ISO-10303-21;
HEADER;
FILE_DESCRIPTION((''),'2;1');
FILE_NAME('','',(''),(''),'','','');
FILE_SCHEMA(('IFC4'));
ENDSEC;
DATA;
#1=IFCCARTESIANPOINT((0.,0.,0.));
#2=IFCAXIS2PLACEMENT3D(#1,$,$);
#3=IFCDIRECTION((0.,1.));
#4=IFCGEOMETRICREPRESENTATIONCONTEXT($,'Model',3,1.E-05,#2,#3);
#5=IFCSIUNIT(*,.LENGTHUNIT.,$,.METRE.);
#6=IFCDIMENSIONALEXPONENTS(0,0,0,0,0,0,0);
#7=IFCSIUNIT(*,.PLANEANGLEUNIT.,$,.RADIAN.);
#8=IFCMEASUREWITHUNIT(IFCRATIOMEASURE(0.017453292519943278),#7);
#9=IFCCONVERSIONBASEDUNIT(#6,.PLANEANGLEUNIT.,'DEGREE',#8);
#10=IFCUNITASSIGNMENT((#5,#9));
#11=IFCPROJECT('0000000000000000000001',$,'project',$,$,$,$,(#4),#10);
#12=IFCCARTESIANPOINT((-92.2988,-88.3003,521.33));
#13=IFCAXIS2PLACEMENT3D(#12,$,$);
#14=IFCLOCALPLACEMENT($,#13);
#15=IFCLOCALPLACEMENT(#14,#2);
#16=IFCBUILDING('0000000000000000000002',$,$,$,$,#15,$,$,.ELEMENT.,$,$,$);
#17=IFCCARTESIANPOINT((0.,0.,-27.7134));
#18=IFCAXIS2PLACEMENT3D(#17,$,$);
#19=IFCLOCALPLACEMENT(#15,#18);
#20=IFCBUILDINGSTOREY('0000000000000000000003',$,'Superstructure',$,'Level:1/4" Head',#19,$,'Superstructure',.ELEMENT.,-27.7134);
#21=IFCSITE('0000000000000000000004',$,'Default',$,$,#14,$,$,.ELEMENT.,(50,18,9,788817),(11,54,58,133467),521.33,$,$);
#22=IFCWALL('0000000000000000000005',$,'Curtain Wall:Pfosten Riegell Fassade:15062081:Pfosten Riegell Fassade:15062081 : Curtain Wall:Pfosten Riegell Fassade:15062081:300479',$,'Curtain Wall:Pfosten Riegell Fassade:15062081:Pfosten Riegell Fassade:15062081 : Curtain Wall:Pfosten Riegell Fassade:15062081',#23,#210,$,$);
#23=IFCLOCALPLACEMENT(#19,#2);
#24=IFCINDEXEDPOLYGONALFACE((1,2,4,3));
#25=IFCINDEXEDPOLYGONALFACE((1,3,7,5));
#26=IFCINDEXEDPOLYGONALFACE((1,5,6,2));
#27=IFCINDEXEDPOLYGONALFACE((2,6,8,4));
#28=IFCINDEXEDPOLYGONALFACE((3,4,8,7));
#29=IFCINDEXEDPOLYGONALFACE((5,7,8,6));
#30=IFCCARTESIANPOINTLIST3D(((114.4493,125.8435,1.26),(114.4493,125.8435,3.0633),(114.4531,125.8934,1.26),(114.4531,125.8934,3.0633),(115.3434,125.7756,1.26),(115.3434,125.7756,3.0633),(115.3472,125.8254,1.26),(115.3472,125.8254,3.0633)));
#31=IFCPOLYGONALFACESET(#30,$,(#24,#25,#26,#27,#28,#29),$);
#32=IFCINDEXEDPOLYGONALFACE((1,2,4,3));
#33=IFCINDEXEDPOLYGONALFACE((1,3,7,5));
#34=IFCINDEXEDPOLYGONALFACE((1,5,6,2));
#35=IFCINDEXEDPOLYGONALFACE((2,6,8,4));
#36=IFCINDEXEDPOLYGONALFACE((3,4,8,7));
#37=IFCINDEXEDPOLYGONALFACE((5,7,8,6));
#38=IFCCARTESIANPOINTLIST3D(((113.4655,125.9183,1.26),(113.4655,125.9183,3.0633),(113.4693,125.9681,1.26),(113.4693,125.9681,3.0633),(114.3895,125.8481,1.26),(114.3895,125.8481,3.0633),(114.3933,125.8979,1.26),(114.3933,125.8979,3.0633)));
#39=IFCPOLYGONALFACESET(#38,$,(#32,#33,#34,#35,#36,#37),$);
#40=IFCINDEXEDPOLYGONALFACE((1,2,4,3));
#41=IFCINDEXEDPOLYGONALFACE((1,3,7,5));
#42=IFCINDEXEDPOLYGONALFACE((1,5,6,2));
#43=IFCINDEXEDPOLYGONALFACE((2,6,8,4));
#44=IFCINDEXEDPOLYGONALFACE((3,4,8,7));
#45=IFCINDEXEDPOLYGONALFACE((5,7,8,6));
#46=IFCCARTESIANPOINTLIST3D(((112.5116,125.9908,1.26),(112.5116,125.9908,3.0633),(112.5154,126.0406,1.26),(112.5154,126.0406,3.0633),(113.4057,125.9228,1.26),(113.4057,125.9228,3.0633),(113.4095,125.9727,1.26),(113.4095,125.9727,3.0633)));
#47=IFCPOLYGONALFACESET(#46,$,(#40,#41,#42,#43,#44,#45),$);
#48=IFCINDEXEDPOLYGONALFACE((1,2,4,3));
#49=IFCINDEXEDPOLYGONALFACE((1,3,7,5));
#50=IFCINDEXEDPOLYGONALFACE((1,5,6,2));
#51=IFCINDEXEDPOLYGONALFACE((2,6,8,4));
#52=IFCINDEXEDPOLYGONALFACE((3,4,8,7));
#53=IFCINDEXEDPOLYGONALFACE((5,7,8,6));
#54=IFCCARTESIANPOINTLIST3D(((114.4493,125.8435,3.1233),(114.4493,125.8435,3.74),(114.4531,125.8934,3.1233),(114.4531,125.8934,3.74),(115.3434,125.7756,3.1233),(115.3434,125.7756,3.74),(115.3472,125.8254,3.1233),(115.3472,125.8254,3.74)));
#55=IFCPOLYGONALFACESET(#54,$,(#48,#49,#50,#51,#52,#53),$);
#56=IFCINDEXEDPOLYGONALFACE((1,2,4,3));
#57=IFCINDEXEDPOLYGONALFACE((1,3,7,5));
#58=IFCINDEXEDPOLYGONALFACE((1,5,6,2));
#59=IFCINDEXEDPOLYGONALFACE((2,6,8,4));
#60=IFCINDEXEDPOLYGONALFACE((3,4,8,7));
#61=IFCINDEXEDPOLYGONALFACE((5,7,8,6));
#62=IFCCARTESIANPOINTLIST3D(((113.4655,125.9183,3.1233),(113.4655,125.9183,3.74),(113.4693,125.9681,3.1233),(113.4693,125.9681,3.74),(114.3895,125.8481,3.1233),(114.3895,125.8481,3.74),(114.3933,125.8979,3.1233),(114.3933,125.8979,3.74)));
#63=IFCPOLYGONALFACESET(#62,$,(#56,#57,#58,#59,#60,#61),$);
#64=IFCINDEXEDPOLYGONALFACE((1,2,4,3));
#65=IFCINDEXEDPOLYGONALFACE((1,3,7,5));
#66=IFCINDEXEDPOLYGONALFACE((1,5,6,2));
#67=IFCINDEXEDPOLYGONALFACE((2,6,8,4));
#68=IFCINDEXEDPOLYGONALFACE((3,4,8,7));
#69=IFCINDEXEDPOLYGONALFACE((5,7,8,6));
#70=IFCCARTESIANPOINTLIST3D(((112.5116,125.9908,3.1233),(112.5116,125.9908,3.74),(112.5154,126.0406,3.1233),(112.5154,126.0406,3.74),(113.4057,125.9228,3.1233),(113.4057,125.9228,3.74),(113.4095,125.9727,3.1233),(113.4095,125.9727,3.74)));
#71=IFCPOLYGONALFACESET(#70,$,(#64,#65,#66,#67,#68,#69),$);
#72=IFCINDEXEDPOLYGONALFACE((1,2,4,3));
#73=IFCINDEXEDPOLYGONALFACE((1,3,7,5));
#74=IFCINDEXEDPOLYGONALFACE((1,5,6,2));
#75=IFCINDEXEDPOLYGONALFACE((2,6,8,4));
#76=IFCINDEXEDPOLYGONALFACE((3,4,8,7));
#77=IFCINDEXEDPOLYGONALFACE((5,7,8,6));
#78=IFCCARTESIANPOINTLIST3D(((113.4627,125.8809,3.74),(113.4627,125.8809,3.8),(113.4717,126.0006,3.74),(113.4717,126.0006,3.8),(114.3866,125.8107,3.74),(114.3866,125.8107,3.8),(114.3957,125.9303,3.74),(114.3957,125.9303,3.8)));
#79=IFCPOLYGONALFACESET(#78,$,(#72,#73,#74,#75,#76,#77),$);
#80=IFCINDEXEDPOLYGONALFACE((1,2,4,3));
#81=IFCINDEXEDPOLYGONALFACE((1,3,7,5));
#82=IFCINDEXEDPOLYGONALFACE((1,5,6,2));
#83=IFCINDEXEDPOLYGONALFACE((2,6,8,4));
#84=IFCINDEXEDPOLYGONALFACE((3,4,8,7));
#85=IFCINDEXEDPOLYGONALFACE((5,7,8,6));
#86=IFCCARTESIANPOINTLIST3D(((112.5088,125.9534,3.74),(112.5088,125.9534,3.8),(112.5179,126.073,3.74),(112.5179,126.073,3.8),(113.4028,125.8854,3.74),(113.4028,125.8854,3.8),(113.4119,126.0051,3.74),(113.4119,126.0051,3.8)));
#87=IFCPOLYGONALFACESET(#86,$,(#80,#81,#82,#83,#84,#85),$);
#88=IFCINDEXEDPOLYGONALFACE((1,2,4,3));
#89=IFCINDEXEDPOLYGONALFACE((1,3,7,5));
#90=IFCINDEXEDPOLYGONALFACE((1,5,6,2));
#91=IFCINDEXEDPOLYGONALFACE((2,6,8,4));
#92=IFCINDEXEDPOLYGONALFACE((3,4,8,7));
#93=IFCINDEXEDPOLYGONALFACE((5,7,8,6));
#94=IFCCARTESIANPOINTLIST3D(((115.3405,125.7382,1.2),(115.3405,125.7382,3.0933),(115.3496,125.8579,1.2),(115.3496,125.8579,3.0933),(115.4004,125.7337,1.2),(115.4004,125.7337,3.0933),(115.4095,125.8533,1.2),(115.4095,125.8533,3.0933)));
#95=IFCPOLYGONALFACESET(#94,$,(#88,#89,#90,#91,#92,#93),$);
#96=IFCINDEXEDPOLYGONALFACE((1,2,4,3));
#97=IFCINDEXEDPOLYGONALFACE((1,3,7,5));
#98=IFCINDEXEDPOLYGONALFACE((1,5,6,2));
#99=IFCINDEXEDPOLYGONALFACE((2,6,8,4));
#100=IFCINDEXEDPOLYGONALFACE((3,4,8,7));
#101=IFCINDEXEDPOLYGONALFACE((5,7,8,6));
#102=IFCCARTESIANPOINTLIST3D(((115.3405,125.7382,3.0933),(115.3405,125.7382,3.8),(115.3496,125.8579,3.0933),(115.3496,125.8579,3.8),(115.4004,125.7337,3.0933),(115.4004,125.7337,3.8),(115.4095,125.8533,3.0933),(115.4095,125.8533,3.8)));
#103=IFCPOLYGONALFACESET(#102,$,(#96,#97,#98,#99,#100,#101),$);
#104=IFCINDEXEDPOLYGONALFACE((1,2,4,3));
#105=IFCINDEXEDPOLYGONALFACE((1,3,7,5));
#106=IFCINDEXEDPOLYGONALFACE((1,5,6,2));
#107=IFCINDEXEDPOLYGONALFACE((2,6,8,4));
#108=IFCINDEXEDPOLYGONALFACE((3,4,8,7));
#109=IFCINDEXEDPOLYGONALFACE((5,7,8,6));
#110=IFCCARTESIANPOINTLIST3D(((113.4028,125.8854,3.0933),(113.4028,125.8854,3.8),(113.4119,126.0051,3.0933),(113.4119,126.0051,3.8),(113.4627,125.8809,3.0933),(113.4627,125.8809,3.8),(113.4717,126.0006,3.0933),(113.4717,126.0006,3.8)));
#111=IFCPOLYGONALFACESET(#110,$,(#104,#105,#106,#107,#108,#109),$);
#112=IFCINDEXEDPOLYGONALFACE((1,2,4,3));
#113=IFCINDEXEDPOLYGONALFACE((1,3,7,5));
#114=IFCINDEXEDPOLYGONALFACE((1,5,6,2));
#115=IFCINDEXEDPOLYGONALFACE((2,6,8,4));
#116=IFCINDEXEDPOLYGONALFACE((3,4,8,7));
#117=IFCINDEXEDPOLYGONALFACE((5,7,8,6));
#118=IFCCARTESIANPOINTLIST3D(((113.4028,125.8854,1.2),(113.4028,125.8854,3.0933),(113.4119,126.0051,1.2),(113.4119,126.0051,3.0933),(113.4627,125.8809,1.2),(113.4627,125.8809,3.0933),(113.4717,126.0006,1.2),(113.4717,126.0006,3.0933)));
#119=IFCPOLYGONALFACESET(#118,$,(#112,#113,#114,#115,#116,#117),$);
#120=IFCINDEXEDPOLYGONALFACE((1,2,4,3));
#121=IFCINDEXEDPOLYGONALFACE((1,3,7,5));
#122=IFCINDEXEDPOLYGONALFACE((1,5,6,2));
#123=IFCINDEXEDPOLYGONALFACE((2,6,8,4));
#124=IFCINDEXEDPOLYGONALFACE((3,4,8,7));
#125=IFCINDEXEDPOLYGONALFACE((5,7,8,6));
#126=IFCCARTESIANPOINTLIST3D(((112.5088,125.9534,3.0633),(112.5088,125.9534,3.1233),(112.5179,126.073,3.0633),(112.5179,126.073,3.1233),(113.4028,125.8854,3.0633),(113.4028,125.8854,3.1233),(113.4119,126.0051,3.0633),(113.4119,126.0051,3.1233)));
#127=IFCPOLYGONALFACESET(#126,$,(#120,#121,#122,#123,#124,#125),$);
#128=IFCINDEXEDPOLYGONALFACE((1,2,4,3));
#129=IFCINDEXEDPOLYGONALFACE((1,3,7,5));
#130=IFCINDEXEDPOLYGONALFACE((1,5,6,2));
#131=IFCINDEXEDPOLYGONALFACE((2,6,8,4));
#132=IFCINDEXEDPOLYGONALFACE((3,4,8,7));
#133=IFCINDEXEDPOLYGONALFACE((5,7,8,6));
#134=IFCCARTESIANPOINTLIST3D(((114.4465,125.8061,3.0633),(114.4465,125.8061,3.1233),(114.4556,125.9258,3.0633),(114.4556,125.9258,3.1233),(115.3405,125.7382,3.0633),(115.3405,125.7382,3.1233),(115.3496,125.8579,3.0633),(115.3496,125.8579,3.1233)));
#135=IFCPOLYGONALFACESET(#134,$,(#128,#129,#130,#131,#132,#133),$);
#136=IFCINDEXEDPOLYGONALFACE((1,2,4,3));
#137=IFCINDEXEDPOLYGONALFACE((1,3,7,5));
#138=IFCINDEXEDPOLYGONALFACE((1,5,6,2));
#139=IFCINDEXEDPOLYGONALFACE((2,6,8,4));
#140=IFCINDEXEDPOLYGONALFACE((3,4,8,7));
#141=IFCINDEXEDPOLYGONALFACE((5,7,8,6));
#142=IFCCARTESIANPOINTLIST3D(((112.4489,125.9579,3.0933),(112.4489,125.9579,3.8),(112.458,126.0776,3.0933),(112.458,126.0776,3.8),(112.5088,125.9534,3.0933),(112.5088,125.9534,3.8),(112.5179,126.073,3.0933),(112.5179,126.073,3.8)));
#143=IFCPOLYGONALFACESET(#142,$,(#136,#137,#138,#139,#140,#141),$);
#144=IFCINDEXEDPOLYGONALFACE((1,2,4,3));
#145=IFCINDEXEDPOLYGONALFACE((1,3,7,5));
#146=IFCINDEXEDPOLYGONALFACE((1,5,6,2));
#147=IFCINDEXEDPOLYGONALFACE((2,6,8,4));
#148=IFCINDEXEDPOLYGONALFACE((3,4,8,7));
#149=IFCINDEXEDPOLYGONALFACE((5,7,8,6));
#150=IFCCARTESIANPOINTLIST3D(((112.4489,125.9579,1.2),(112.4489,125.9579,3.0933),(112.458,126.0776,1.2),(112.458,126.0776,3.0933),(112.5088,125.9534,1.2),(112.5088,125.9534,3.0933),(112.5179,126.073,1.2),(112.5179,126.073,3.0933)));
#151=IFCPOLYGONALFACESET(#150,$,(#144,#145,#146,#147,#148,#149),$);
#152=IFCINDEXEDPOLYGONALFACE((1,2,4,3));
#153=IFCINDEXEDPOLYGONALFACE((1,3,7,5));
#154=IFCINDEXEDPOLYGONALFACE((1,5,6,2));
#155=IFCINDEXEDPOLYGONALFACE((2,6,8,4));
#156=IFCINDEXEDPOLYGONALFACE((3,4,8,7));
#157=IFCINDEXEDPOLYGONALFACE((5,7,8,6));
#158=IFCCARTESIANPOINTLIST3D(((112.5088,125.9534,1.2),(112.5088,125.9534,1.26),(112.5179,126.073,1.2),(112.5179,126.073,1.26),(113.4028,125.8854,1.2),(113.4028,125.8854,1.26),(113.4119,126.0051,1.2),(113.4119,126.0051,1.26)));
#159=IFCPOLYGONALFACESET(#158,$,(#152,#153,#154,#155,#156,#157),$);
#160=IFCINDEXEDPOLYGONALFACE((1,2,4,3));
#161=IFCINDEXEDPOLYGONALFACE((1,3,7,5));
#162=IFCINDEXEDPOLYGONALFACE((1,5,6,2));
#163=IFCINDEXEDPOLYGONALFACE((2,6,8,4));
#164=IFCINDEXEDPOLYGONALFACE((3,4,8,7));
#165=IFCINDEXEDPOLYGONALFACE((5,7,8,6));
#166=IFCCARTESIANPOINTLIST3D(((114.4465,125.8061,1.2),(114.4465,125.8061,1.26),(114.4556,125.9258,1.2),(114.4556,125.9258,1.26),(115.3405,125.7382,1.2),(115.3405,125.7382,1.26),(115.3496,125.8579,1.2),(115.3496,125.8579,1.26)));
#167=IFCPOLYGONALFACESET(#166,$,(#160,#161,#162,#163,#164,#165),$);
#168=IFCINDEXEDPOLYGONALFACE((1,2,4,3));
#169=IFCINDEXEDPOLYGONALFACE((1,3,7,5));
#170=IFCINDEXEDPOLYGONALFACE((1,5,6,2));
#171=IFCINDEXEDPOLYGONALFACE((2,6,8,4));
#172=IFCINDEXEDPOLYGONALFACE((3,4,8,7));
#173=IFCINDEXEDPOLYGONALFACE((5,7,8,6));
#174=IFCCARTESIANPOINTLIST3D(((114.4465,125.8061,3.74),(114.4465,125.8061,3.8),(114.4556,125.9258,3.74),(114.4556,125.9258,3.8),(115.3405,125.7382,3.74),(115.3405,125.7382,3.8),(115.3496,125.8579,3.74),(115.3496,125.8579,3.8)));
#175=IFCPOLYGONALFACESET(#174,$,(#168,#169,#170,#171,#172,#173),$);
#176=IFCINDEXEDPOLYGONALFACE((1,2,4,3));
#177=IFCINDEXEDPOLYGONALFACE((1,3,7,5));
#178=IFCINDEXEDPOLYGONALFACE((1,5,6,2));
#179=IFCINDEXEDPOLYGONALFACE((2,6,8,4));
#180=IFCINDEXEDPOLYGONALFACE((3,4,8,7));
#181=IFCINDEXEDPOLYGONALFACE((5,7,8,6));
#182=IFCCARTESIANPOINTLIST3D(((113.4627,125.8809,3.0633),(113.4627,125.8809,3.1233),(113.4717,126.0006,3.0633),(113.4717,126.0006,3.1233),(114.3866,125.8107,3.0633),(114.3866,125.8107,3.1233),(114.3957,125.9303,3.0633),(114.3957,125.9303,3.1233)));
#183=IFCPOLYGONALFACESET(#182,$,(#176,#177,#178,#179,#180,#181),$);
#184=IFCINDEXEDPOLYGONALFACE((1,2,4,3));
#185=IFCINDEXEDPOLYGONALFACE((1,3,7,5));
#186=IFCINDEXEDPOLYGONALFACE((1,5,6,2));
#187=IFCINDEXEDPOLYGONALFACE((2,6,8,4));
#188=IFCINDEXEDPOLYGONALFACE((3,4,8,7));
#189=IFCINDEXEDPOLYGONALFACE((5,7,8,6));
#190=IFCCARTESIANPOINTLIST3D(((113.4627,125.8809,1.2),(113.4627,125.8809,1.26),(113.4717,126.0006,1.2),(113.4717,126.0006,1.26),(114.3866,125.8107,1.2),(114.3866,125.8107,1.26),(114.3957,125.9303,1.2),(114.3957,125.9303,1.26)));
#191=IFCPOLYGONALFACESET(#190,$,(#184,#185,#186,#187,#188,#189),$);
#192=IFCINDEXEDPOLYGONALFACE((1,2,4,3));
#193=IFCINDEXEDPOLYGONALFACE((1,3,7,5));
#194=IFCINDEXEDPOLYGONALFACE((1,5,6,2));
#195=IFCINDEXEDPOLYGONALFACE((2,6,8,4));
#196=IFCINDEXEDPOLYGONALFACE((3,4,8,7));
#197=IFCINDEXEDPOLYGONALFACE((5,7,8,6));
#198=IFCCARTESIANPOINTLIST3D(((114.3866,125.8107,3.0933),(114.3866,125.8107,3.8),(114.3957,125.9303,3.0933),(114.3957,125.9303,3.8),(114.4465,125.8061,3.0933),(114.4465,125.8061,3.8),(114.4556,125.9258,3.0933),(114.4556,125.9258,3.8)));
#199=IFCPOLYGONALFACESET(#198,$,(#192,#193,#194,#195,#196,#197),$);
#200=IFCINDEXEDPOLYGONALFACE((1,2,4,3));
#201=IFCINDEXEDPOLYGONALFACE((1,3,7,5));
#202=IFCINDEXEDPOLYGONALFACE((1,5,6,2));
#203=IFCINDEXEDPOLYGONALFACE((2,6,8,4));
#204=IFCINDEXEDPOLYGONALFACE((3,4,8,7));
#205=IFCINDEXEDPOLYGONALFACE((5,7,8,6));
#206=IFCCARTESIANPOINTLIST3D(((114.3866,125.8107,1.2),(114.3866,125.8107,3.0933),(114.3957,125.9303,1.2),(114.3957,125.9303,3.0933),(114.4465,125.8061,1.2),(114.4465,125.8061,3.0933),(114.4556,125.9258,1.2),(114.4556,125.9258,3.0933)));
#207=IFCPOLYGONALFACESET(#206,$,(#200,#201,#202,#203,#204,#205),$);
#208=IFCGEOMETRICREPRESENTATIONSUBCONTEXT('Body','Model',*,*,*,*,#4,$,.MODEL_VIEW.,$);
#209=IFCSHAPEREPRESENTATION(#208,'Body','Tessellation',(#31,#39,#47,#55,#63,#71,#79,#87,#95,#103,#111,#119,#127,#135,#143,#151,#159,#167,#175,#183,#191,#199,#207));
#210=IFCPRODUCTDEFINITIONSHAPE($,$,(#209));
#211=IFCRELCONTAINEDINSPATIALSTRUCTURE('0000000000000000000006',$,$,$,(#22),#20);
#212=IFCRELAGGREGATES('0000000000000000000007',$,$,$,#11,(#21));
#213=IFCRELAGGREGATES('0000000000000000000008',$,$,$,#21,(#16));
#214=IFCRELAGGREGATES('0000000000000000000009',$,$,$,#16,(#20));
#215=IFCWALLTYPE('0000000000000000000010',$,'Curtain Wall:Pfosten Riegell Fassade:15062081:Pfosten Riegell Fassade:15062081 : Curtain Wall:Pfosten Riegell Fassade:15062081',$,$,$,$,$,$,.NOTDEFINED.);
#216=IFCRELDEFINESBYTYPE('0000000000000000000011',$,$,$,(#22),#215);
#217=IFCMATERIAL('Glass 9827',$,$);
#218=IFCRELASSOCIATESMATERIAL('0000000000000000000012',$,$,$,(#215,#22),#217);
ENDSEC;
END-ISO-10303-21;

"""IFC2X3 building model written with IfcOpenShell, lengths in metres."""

from ifc_helpers import new_model, entity, si_unit, converted_unit, direction, frame, frame_2d, origin, origin_2d_with_axis, place, context, subcontext, project, spatial, rectangle, extrude, material, type_object, element, save


model = new_model("IFC2X3")

# Units and contexts
model_context = context("Model", 3, precision=1e-05, world=origin(), true_north=direction((0.0, 1.0)))
body_context = subcontext(model_context, "Body", "Model", "MODEL_VIEW")
ifc_project = project(units=[si_unit("LENGTHUNIT", "METRE"), converted_unit("PLANEANGLEUNIT", "DEGREE", entity("IfcRatioMeasure", 0.017453292519943278), si_unit("PLANEANGLEUNIT", "RADIAN"), dimensions=[0, 0, 0, 0, 0, 0, 0])], contexts=[model_context])

# Site, building, storey
site_placement = place(None, frame((-92.2988, -88.3003, 521.33)))
site = spatial("IfcSite", under=ifc_project, at=site_placement, Name="Default", CompositionType="ELEMENT", RefLatitude=(50, 18, 9, 788817), RefLongitude=(11, 54, 58, 133467), RefElevation=521.33)
building_placement = place(site_placement, origin())
building = spatial("IfcBuilding", under=site, at=building_placement, CompositionType="ELEMENT")
storey_placement = place(building_placement, frame((0.0, 0.0, -27.7134)))
storey = spatial("IfcBuildingStorey", under=building, at=storey_placement, Name="Superstructure", ObjectType="Level:1/4\" Head", LongName="Superstructure", CompositionType="ELEMENT", Elevation=-27.7134)

# Wall
ifc_material_1 = material(Name="Glass 9827")
wall_type_1 = type_object("IfcWallType", Name="Curtain Wall:Pfosten Riegell Fassade:15062081:Pfosten Riegell Fassade:15062081 : Curtain Wall:Pfosten Riegell Fassade:15062081", PredefinedType="NOTDEFINED", material=ifc_material_1)
wall_1_placement = place(storey_placement, frame((112.4489, 125.7337, 1.2)))
element("IfcWall", 1, at=wall_1_placement, inside=storey, type_object=wall_type_1, material=ifc_material_1, Name="Curtain Wall:Pfosten Riegell Fassade:15062081:Pfosten Riegell Fassade:15062081 : Curtain Wall:Pfosten Riegell Fassade:15062081:300479", ObjectType="Curtain Wall:Pfosten Riegell Fassade:15062081:Pfosten Riegell Fassade:15062081 : Curtain Wall:Pfosten Riegell Fassade:15062081", context=body_context, shape_type="SweptSolid", body=[
    extrude(rectangle(XDim=0.8966, YDim=0.05, at=frame_2d((0.0, 0.0), x_axis=(1.0, 0.0))), frame((2.4493, 0.1008, 0.06), z_axis=(0.0, 0.0, 1.0), x_axis=(0.997125, -0.07577, 0.0)), (0.0, 0.0, 1.0), 1.8033),
    extrude(rectangle(XDim=0.9266, YDim=0.05, at=frame_2d((0.0, 0.0), x_axis=(1.0, 0.0))), frame((1.4805, 0.1745, 0.06), z_axis=(0.0, 0.0, 1.0), x_axis=(0.997125, -0.07577, 0.0)), (0.0, 0.0, 1.0), 1.8033),
    extrude(rectangle(XDim=0.8966, YDim=0.05, at=frame_2d((0.0, 0.0), x_axis=(1.0, 0.0))), frame((0.5116, 0.2481, 0.06), z_axis=(0.0, 0.0, 1.0), x_axis=(0.997125, -0.07577, 0.0)), (0.0, 0.0, 1.0), 1.8033),
    extrude(rectangle(XDim=0.8966, YDim=0.05, at=frame_2d((0.0, 0.0), x_axis=(1.0, 0.0))), frame((2.4493, 0.1008, 1.9233), z_axis=(0.0, 0.0, 1.0), x_axis=(0.997125, -0.07577, 0.0)), (0.0, 0.0, 1.0), 0.6167),
    extrude(rectangle(XDim=0.9266, YDim=0.05, at=frame_2d((0.0, 0.0), x_axis=(1.0, 0.0))), frame((1.4805, 0.1745, 1.9233), z_axis=(0.0, 0.0, 1.0), x_axis=(0.997125, -0.07577, 0.0)), (0.0, 0.0, 1.0), 0.6167),
    extrude(rectangle(XDim=0.8966, YDim=0.05, at=frame_2d((0.0, 0.0), x_axis=(1.0, 0.0))), frame((0.5116, 0.2481, 1.9233), z_axis=(0.0, 0.0, 1.0), x_axis=(0.997125, -0.07577, 0.0)), (0.0, 0.0, 1.0), 0.6167),
    extrude(rectangle(XDim=0.9266, YDim=0.12, at=frame_2d((0.0, 0.0), x_axis=(1.0, 0.0))), frame((1.4803, 0.172, 2.54), z_axis=(0.0, 0.0, 1.0), x_axis=(0.997125, -0.07577, 0.0)), (0.0, 0.0, 1.0), 0.06),
    extrude(rectangle(XDim=0.8966, YDim=0.12, at=frame_2d((0.0, 0.0), x_axis=(1.0, 0.0))), frame((0.5114, 0.2456, 2.54), z_axis=(0.0, 0.0, 1.0), x_axis=(0.997125, -0.07577, 0.0)), (0.0, 0.0, 1.0), 0.06),
    extrude(rectangle(XDim=0.12, YDim=0.06, at=frame_2d((0.0, 0.0), x_axis=(1.0, 0.0))), frame((2.9261, 0.0621, 0.0), z_axis=(0.0, 0.0, 1.0), x_axis=(-0.07577, -0.997125, 0.0)), (0.0, 0.0, 1.0), 1.8933),
    extrude(rectangle(XDim=0.12, YDim=0.06, at=frame_2d((0.0, 0.0), x_axis=(1.0, 0.0))), frame((2.9261, 0.0621, 1.8933), z_axis=(0.0, 0.0, 1.0), x_axis=(-0.07577, -0.997125, 0.0)), (0.0, 0.0, 1.0), 0.7067),
    extrude(rectangle(XDim=0.06, YDim=0.12, at=origin_2d_with_axis()), frame((0.9884, 0.2093, 1.8933), z_axis=(0.0, 0.0, 1.0), x_axis=(-0.997125, 0.07577, 0.0)), (0.0, 0.0, 1.0), 0.7067),
    extrude(rectangle(XDim=0.06, YDim=0.12, at=origin_2d_with_axis()), frame((0.9884, 0.2093, 0.0), z_axis=(0.0, 0.0, 1.0), x_axis=(-0.997125, 0.07577, 0.0)), (0.0, 0.0, 1.0), 1.8933),
    extrude(rectangle(XDim=0.8966, YDim=0.12, at=frame_2d((0.0, 0.0), x_axis=(1.0, 0.0))), frame((0.5114, 0.2456, 1.8633), z_axis=(0.0, 0.0, 1.0), x_axis=(0.997125, -0.07577, 0.0)), (0.0, 0.0, 1.0), 0.06),
    extrude(rectangle(XDim=0.8966, YDim=0.12, at=frame_2d((0.0, 0.0), x_axis=(1.0, 0.0))), frame((2.4491, 0.0983, 1.8633), z_axis=(0.0, 0.0, 1.0), x_axis=(0.997125, -0.07577, 0.0)), (0.0, 0.0, 1.0), 0.06),
    extrude(rectangle(XDim=0.06, YDim=0.12, at=origin_2d_with_axis()), frame((0.0345, 0.2818, 1.8933), z_axis=(0.0, 0.0, 1.0), x_axis=(-0.997125, 0.07577, 0.0)), (0.0, 0.0, 1.0), 0.7067),
    extrude(rectangle(XDim=0.06, YDim=0.12, at=origin_2d_with_axis()), frame((0.0345, 0.2818, 0.0), z_axis=(0.0, 0.0, 1.0), x_axis=(-0.997125, 0.07577, 0.0)), (0.0, 0.0, 1.0), 1.8933),
    extrude(rectangle(XDim=0.8966, YDim=0.12, at=frame_2d((0.0, 0.0), x_axis=(1.0, 0.0))), frame((0.5114, 0.2456, 0.0), z_axis=(0.0, 0.0, 1.0), x_axis=(-0.997125, 0.07577, 0.0)), (0.0, 0.0, 1.0), 0.06),
    extrude(rectangle(XDim=0.8966, YDim=0.12, at=frame_2d((0.0, 0.0), x_axis=(1.0, 0.0))), frame((2.4491, 0.0983, 0.0), z_axis=(0.0, 0.0, 1.0), x_axis=(-0.997125, 0.07577, 0.0)), (0.0, 0.0, 1.0), 0.06),
    extrude(rectangle(XDim=0.8966, YDim=0.12, at=frame_2d((0.0, 0.0), x_axis=(1.0, 0.0))), frame((2.4491, 0.0983, 2.54), z_axis=(0.0, 0.0, 1.0), x_axis=(0.997125, -0.07577, 0.0)), (0.0, 0.0, 1.0), 0.06),
    extrude(rectangle(XDim=0.9266, YDim=0.12, at=frame_2d((0.0, 0.0), x_axis=(1.0, 0.0))), frame((1.4803, 0.172, 1.8633), z_axis=(0.0, 0.0, 1.0), x_axis=(0.997125, -0.07577, 0.0)), (0.0, 0.0, 1.0), 0.06),
    extrude(rectangle(XDim=0.9266, YDim=0.12, at=frame_2d((0.0, 0.0), x_axis=(1.0, 0.0))), frame((1.4803, 0.172, 0.0), z_axis=(0.0, 0.0, 1.0), x_axis=(-0.997125, 0.07577, 0.0)), (0.0, 0.0, 1.0), 0.06),
    extrude(rectangle(XDim=0.06, YDim=0.12, at=origin_2d_with_axis()), frame((1.9722, 0.1346, 1.8933), z_axis=(0.0, 0.0, 1.0), x_axis=(-0.997125, 0.07577, 0.0)), (0.0, 0.0, 1.0), 0.7067),
    extrude(rectangle(XDim=0.06, YDim=0.12, at=origin_2d_with_axis()), frame((1.9722, 0.1346, 0.0), z_axis=(0.0, 0.0, 1.0), x_axis=(-0.997125, 0.07577, 0.0)), (0.0, 0.0, 1.0), 1.8933),
])

save(model, "model.ifc")
